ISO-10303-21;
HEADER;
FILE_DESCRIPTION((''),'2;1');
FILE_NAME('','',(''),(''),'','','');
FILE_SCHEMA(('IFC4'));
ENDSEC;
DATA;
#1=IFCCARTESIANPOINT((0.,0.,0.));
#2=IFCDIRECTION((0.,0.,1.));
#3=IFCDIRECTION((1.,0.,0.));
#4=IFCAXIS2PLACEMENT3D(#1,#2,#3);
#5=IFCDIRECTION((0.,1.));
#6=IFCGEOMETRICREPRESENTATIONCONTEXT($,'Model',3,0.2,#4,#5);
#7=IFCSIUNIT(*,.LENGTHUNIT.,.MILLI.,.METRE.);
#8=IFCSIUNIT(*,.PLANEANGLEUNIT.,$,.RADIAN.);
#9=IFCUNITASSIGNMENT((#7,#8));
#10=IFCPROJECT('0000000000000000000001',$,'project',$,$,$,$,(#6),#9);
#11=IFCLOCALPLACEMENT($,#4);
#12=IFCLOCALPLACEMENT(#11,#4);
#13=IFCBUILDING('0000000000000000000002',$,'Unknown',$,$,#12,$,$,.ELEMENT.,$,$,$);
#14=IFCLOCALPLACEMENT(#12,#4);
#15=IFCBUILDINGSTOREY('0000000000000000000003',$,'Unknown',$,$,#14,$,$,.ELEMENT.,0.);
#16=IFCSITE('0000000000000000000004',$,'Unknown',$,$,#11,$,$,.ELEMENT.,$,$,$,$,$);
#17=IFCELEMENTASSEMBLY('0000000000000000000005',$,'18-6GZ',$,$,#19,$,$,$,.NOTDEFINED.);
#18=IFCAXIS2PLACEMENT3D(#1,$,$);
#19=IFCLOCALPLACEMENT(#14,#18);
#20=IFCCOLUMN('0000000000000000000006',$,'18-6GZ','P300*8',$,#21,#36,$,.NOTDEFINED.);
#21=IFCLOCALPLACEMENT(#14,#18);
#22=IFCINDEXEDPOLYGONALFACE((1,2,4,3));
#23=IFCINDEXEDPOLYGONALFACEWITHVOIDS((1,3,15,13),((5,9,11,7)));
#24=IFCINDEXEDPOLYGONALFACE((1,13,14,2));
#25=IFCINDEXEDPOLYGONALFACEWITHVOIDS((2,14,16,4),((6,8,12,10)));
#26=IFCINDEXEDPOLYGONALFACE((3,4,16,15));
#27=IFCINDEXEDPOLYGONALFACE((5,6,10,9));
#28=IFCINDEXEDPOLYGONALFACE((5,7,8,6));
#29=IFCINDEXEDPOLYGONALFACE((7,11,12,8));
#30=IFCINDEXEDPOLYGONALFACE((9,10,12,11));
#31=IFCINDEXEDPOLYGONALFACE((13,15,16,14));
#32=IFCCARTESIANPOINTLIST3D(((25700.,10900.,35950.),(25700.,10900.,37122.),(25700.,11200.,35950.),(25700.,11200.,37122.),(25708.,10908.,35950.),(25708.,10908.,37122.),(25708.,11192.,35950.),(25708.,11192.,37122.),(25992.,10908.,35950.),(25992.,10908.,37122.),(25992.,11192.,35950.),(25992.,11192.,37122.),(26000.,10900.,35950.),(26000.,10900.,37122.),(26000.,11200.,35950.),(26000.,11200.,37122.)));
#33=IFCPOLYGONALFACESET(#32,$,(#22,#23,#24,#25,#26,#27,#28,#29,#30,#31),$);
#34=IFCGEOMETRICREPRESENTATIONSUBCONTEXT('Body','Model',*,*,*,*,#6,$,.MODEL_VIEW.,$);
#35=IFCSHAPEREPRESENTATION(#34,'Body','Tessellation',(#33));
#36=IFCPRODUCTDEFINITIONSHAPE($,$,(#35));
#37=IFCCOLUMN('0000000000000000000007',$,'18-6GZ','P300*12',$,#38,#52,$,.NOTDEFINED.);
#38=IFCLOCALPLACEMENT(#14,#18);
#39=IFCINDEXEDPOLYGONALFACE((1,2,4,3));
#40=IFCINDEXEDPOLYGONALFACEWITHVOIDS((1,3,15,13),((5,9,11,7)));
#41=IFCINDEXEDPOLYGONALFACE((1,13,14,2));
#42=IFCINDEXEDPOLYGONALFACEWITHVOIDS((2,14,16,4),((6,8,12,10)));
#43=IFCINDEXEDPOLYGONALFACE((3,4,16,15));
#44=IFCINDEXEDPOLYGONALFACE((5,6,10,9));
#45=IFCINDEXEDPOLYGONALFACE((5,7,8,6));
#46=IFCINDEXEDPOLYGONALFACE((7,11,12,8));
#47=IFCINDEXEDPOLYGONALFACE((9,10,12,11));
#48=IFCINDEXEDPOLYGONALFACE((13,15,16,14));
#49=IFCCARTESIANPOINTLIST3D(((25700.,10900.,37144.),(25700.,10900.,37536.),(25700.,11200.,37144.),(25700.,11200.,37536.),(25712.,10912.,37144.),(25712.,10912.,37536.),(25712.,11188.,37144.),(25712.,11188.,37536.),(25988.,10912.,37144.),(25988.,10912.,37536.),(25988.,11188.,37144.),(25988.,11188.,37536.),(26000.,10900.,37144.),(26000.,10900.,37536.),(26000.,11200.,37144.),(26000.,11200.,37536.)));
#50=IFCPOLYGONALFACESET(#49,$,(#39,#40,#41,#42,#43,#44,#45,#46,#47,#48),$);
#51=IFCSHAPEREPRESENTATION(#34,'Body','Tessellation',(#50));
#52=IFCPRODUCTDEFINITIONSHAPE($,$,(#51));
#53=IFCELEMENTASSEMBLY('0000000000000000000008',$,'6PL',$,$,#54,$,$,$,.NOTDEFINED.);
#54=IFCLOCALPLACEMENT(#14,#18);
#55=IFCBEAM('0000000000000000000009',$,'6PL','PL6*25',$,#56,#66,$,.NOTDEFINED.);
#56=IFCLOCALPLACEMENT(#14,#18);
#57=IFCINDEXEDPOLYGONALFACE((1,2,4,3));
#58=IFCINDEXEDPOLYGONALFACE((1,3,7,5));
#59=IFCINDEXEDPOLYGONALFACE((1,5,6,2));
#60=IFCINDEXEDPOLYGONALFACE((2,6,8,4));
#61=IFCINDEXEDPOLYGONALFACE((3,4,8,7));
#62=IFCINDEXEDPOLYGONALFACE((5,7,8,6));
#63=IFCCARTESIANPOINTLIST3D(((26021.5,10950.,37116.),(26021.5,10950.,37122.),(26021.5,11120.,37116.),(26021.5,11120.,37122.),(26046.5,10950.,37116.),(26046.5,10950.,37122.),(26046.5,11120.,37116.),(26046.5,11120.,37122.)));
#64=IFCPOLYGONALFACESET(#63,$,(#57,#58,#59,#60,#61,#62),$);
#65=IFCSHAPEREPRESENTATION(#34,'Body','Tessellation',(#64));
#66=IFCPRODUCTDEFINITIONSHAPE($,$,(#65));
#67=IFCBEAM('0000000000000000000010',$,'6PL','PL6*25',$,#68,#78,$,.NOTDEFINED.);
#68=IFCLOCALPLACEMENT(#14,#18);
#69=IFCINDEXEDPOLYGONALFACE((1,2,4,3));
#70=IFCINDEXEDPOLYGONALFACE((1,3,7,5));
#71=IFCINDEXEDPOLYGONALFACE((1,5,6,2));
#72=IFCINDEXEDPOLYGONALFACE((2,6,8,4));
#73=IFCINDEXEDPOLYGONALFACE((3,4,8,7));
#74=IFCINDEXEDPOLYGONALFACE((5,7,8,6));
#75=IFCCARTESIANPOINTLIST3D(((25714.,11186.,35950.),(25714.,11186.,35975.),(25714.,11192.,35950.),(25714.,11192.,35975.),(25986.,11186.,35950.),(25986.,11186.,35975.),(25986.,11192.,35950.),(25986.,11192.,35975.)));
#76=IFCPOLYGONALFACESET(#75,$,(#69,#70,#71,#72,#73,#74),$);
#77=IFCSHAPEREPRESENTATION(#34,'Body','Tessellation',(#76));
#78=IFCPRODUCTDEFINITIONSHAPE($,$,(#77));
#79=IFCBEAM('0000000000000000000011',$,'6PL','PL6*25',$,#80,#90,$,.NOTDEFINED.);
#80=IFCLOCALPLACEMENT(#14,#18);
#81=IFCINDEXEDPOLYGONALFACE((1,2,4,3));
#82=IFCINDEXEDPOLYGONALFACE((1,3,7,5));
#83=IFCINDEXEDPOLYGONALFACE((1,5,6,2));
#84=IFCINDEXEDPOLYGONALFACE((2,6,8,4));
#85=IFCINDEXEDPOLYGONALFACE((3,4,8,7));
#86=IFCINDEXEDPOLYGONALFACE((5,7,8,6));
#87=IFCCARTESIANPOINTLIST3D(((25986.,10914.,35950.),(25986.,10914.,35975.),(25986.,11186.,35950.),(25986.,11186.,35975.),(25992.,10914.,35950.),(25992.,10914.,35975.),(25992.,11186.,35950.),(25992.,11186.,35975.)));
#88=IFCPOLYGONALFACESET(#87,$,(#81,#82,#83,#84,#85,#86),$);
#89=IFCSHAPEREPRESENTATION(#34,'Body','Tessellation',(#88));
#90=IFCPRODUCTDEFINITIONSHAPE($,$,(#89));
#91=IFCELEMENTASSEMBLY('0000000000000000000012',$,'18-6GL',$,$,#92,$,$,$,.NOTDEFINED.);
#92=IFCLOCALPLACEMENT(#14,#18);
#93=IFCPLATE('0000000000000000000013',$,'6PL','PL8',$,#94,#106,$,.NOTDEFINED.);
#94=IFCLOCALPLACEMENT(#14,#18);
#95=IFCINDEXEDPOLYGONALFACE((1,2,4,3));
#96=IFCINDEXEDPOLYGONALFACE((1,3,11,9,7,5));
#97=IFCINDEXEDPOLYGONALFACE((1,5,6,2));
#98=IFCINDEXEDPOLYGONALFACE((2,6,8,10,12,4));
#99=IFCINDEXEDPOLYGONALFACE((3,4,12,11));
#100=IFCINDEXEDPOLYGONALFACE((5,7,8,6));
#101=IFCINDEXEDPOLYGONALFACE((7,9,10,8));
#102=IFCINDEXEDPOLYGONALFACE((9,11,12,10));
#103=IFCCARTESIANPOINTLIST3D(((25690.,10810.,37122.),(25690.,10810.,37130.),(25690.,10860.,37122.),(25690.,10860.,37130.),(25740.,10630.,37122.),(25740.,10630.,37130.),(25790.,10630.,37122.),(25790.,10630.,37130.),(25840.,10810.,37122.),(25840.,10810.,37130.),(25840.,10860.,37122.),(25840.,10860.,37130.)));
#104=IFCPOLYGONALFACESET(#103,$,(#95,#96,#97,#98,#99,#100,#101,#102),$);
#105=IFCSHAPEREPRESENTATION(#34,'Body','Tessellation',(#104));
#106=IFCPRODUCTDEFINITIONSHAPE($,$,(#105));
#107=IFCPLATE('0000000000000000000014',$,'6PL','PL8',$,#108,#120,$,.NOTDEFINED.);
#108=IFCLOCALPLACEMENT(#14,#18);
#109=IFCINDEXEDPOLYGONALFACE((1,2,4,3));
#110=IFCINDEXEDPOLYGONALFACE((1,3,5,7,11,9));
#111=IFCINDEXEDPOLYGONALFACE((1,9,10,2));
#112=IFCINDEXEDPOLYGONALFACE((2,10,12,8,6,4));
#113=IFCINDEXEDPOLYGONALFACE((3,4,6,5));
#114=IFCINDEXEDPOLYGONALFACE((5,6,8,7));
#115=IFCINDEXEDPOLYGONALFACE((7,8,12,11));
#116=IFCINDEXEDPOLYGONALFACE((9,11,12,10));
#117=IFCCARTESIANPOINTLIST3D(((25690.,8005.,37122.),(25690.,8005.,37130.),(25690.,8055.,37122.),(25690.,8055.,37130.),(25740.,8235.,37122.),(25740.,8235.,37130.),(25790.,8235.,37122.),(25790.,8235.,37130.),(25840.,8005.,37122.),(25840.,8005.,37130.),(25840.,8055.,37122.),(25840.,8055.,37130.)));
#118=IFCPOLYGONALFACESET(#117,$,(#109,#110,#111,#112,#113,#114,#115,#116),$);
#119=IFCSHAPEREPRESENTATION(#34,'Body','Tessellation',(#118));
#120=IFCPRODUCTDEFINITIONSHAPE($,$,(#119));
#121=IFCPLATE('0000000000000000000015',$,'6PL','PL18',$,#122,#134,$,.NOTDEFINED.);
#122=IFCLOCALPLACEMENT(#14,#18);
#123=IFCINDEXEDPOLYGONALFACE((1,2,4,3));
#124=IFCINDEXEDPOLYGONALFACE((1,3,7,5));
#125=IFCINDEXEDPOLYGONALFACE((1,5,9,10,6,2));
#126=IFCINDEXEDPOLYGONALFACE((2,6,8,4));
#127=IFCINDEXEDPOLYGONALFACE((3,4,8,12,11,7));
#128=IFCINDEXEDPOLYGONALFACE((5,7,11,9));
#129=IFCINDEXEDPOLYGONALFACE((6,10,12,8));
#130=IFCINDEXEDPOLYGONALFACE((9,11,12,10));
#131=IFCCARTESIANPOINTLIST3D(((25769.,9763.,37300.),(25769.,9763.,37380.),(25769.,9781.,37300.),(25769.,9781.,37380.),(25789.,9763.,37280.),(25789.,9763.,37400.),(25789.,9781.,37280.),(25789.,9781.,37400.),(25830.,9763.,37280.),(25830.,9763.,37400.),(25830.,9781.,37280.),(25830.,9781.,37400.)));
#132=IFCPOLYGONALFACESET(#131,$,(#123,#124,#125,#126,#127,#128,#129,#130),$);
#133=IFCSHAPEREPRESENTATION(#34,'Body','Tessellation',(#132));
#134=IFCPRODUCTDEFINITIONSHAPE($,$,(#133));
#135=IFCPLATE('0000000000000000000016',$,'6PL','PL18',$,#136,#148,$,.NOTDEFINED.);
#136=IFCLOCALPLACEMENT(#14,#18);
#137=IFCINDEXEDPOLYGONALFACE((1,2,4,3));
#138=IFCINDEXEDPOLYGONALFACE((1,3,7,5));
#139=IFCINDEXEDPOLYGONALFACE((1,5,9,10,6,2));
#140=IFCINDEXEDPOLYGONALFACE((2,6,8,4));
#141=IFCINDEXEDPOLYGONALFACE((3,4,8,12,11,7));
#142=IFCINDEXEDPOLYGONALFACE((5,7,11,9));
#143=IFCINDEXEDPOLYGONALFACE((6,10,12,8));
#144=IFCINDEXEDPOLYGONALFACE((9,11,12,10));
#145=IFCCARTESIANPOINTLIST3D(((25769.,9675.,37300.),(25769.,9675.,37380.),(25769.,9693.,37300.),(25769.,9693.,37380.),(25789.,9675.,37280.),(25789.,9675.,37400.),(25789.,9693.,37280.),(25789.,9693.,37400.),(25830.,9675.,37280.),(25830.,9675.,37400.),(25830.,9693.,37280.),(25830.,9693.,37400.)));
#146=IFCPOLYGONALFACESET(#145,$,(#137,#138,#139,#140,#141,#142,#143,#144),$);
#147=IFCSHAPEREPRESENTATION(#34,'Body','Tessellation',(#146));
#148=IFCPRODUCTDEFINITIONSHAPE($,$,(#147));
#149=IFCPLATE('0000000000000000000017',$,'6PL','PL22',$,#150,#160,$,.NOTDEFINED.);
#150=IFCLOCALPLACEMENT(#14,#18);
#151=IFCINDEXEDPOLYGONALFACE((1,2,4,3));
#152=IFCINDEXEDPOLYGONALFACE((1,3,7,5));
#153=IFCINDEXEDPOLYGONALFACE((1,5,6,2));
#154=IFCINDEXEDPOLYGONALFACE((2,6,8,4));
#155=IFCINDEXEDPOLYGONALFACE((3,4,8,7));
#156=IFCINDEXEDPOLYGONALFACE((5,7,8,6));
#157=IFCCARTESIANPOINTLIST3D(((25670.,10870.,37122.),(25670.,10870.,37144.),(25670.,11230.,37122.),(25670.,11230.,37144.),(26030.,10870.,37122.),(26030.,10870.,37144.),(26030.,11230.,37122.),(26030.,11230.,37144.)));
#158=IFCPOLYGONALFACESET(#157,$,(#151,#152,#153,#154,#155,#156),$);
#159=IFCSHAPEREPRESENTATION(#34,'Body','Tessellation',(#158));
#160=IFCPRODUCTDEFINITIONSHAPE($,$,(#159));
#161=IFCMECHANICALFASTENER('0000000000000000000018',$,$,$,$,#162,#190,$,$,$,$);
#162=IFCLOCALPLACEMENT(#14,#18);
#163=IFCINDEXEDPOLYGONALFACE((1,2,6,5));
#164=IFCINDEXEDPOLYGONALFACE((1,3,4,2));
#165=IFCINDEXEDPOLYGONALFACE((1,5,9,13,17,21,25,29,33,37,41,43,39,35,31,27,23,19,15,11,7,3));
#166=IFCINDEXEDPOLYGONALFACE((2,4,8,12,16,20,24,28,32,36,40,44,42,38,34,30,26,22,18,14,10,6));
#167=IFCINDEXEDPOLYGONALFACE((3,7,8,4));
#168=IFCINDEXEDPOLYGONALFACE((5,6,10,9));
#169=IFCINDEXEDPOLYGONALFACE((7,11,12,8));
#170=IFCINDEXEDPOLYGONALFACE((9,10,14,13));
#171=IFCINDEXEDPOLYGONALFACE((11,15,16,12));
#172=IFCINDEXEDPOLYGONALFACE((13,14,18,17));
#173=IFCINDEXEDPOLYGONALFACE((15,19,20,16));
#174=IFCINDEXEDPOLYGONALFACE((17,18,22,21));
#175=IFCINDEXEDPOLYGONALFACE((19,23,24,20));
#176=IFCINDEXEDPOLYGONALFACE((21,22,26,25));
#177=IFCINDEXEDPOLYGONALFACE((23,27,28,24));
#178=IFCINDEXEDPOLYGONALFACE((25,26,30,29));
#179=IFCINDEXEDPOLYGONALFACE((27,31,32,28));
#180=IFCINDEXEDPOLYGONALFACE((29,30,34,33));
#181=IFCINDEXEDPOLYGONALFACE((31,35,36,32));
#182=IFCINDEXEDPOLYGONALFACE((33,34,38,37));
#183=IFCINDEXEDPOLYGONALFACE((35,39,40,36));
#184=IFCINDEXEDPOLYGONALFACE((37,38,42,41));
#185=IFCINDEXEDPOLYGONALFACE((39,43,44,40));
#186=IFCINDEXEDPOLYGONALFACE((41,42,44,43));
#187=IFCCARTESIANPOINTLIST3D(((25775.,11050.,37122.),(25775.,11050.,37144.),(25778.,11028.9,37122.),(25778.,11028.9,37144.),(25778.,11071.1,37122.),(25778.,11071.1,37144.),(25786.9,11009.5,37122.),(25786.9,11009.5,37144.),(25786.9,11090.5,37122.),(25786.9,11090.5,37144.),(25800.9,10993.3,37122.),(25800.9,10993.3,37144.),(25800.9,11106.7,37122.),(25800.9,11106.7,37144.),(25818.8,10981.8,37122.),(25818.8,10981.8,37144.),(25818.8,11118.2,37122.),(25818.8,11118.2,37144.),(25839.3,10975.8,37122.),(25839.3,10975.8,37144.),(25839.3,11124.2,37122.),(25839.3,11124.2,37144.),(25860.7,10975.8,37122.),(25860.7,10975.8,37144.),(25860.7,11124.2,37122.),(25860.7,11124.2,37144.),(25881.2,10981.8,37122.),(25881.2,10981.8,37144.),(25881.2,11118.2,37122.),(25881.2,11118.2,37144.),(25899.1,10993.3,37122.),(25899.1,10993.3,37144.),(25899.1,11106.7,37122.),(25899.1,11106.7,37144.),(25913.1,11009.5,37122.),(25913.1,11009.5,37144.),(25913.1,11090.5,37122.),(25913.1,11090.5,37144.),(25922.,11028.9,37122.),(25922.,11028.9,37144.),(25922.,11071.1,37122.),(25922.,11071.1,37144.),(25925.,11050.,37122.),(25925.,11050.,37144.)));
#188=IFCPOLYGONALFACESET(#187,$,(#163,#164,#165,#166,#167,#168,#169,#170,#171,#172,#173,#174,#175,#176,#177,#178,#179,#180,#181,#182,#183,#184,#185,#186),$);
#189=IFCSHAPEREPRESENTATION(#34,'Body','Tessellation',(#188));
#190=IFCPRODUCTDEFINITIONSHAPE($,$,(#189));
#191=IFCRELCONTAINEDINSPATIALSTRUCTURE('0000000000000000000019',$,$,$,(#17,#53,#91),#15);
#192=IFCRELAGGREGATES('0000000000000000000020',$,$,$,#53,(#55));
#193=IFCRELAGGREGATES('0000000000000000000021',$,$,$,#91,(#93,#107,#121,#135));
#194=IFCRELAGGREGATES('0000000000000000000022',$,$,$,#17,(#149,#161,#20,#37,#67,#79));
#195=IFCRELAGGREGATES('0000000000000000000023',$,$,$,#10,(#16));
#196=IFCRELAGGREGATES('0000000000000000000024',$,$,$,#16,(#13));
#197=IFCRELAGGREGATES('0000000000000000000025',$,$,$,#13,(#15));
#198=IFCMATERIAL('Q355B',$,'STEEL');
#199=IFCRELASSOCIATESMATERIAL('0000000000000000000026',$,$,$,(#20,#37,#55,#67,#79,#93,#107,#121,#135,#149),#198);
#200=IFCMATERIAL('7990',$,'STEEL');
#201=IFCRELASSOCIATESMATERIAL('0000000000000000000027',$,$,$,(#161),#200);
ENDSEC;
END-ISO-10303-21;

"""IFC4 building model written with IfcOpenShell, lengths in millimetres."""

from ifc_helpers import new_model, si_unit, direction, frame, origin_with_axes, place, context, subcontext, project, spatial, line, arc, indexed_curve, outline, extrude, source, transform, mapped, material, element, aggregate, save


model = new_model("IFC4")

# Units and contexts
model_context = context("Model", 3, precision=0.2, world=origin_with_axes(), true_north=direction((0.0, 1.0)))
body_context = subcontext(model_context, "Body", "Model", "MODEL_VIEW")
ifc_project = project(units=[si_unit("LENGTHUNIT", "METRE", prefix="MILLI"), si_unit("PLANEANGLEUNIT", "RADIAN")], contexts=[model_context])

# Site, building, storey
site_placement = place(None, origin_with_axes())
site = spatial("IfcSite", under=ifc_project, at=site_placement, Name="Unknown", CompositionType="ELEMENT")
building_placement = place(site_placement, origin_with_axes())
building = spatial("IfcBuilding", under=site, at=building_placement, Name="Unknown", CompositionType="ELEMENT")
storey_placement = place(building_placement, origin_with_axes())
storey = spatial("IfcBuildingStorey", under=building, at=storey_placement, Name="Unknown", CompositionType="ELEMENT", Elevation=0.0)

# Element assembly, columns
assembly_1_placement = place(storey_placement, frame((25850.0, 11050.0, 35950.0), z_axis=(-1.0, 0.0, 0.0), x_axis=(0.0, 0.0, 1.0)))
assembly_1 = element("IfcElementAssembly", 1, at=assembly_1_placement, inside=storey, Name="18-6GZ", PredefinedType="NOTDEFINED")
ifc_material_1 = material(Name="Q355B", Category="STEEL")
column_1_placement = place(assembly_1_placement, origin_with_axes())
column_1 = element("IfcColumn", 2, at=column_1_placement, material=ifc_material_1, Name="18-6GZ", Description="P300*8", PredefinedType="NOTDEFINED", context=body_context, shape_type="SolidModel", body=[
    extrude(outline(indexed_curve([(-150.0, -150.0), (150.0, -150.0), (150.0, 150.0), (-150.0, 150.0)], segments=[line(1, 2, 3, 4, 1)]), holes=[indexed_curve([(-142.0, -142.0), (-142.0, 142.0), (142.0, 142.0), (142.0, -142.0)], segments=[line(1, 2, 3, 4, 1)])]), frame((0.0, 0.0, 0.0), z_axis=(-1.0, 0.0, 0.0), x_axis=(0.0, 0.0, 1.0)), (0.0, 0.0, -1.0), 1172.0),
])
column_2_placement = place(assembly_1_placement, frame((1194.0, 0.0, 0.0), z_axis=(0.0, 0.0, 1.0), x_axis=(1.0, 0.0, 0.0)))
column_2 = element("IfcColumn", 3, at=column_2_placement, material=ifc_material_1, Name="18-6GZ", Description="P300*12", PredefinedType="NOTDEFINED", context=body_context, shape_type="SolidModel", body=[
    extrude(outline(indexed_curve([(-150.0, -150.0), (150.0, -150.0), (150.0, 150.0), (-150.0, 150.0)], segments=[line(1, 2, 3, 4, 1)]), holes=[indexed_curve([(-138.0, -138.0), (-138.0, 138.0), (138.0, 138.0), (138.0, -138.0)], segments=[line(1, 2, 3, 4, 1)])]), frame((0.0, 0.0, 0.0), z_axis=(-1.0, 0.0, 0.0), x_axis=(0.0, 0.0, 1.0)), (0.0, 0.0, -1.0), 392.0),
])

# Element assembly, beam
assembly_2_placement = place(storey_placement, frame((26034.0, 10950.0, 37119.0), z_axis=(0.0, 0.0, -1.0), x_axis=(0.0, 1.0, 0.0)))
assembly_2 = element("IfcElementAssembly", 4, at=assembly_2_placement, inside=storey, Name="6PL", PredefinedType="NOTDEFINED")
beam_1_placement = place(assembly_2_placement, origin_with_axes())
beam_1 = element("IfcBeam", 5, at=beam_1_placement, material=ifc_material_1, Name="6PL", Description="PL6*25", PredefinedType="NOTDEFINED", context=body_context, shape_type="SolidModel", body=[
    extrude(outline(indexed_curve([(-3.0, -12.5), (3.0, -12.5), (3.0, 12.5), (-3.0, 12.5)], segments=[line(1, 2, 3, 4, 1)])), frame((0.0, 0.0, 0.0), z_axis=(-1.0, 0.0, 0.0), x_axis=(0.0, 0.0, 1.0)), (0.0, 0.0, -1.0), 170.0),
])
aggregate(assembly_2, [beam_1])

# Beams
beam_2_placement = place(assembly_1_placement, frame((12.5, 139.0, -136.0), z_axis=(0.0, 1.0, 0.0), x_axis=(0.0, 0.0, 1.0)))
beam_2 = element("IfcBeam", 6, at=beam_2_placement, material=ifc_material_1, Name="6PL", Description="PL6*25", PredefinedType="NOTDEFINED", context=body_context, shape_type="SolidModel", body=[
    extrude(outline(indexed_curve([(-3.0, -12.5), (3.0, -12.5), (3.0, 12.5), (-3.0, 12.5)], segments=[line(1, 2, 3, 4, 1)])), frame((0.0, 0.0, 0.0), z_axis=(-1.0, 0.0, 0.0), x_axis=(0.0, 0.0, 1.0)), (0.0, 0.0, -1.0), 272.0),
])
beam_3_placement = place(assembly_1_placement, frame((12.5, -136.0, -139.0), z_axis=(0.0, 0.0, -1.0), x_axis=(0.0, 1.0, 0.0)))
beam_3 = element("IfcBeam", 7, at=beam_3_placement, material=ifc_material_1, Name="6PL", Description="PL6*25", PredefinedType="NOTDEFINED", context=body_context, shape_type="SolidModel", body=[
    extrude(outline(indexed_curve([(-3.0, -12.5), (3.0, -12.5), (3.0, 12.5), (-3.0, 12.5)], segments=[line(1, 2, 3, 4, 1)])), frame((0.0, 0.0, 0.0), z_axis=(-1.0, 0.0, 0.0), x_axis=(0.0, 0.0, 1.0)), (0.0, 0.0, -1.0), 272.0),
])

# Element assembly, plates
assembly_3_placement = place(storey_placement, frame((25765.0, 10900.0, 37340.0), z_axis=(-1.0, 0.0, 0.0), x_axis=(0.0, -1.0, 0.0)))
assembly_3 = element("IfcElementAssembly", 8, at=assembly_3_placement, inside=storey, Name="18-6GL", PredefinedType="NOTDEFINED")
plate_1_placement = place(assembly_3_placement, frame((90.0, -214.0, -75.0), z_axis=(0.0, 1.0, 0.0), x_axis=(-1.0, 0.0, 0.0)))
plate_1 = element("IfcPlate", 9, at=plate_1_placement, material=ifc_material_1, Name="6PL", Description="PL8", PredefinedType="NOTDEFINED", context=body_context, shape_type="SolidModel", body=[
    extrude(outline(indexed_curve([(0.0, 0.0), (50.0, 0.0), (50.0, 150.0), (0.0, 150.0), (-180.0, 100.0), (-180.0, 50.0)], segments=[line(1, 2, 3, 4, 5, 6, 1)])), frame((0.0, 0.0, 4.0), z_axis=(0.0, 0.0, 1.0), x_axis=(1.0, 0.0, 0.0)), (0.0, 0.0, -1.0), 8.0),
])
plate_2_placement = place(assembly_3_placement, frame((2845.0, -214.0, -75.0), z_axis=(0.0, -1.0, 0.0), x_axis=(1.0, 0.0, 0.0)))
plate_2 = element("IfcPlate", 10, at=plate_2_placement, material=ifc_material_1, Name="6PL", Description="PL8", PredefinedType="NOTDEFINED", context=body_context, shape_type="SolidModel", body=[
    extrude(outline(indexed_curve([(0.0, 0.0), (50.0, 0.0), (50.0, 150.0), (0.0, 150.0), (-180.0, 100.0), (-180.0, 50.0)], segments=[line(1, 2, 3, 4, 5, 6, 1)])), frame((0.0, 0.0, 4.0), z_axis=(0.0, 0.0, 1.0), x_axis=(1.0, 0.0, 0.0)), (0.0, 0.0, -1.0), 8.0),
])
plate_3_placement = place(assembly_3_placement, frame((1128.0, -60.0, -65.0), z_axis=(-1.0, 0.0, 0.0), x_axis=(0.0, 0.0, 1.0)))
plate_3 = element("IfcPlate", 11, at=plate_3_placement, material=ifc_material_1, Name="6PL", Description="PL18", PredefinedType="NOTDEFINED", context=body_context, shape_type="SolidModel", body=[
    extrude(outline(indexed_curve([(0.0, 0.0), (41.0, 0.0), (61.0, 20.0), (61.0, 100.0), (41.0, 120.0), (0.0, 120.0)], segments=[line(1, 2, 3, 4, 5, 6, 1)])), frame((0.0, 0.0, 9.0), z_axis=(0.0, 0.0, 1.0), x_axis=(1.0, 0.0, 0.0)), (0.0, 0.0, -1.0), 18.0),
])
plate_4_placement = place(assembly_3_placement, frame((1216.0, -60.0, -65.0), z_axis=(-1.0, 0.0, 0.0), x_axis=(0.0, 0.0, 1.0)))
plate_4 = element("IfcPlate", 12, at=plate_4_placement, material=ifc_material_1, Name="6PL", Description="PL18", PredefinedType="NOTDEFINED", context=body_context, shape_type="SolidModel", body=[
    extrude(outline(indexed_curve([(0.0, 0.0), (41.0, 0.0), (61.0, 20.0), (61.0, 100.0), (41.0, 120.0), (0.0, 120.0)], segments=[line(1, 2, 3, 4, 5, 6, 1)])), frame((0.0, 0.0, 9.0), z_axis=(0.0, 0.0, 1.0), x_axis=(1.0, 0.0, 0.0)), (0.0, 0.0, -1.0), 18.0),
])
aggregate(assembly_3, [plate_1, plate_2, plate_3, plate_4])

# Plate
plate_5_placement = place(assembly_1_placement, frame((1183.0, -180.0, -180.0), z_axis=(-1.0, 0.0, 0.0), x_axis=(0.0, 0.0, 1.0)))
plate_5 = element("IfcPlate", 13, at=plate_5_placement, material=ifc_material_1, Name="6PL", Description="PL22", PredefinedType="NOTDEFINED", context=body_context, shape_type="SolidModel", body=[
    extrude(outline(indexed_curve([(0.0, 0.0), (360.0, 0.0), (360.0, 360.0), (0.0, 360.0)], segments=[line(1, 2, 3, 4, 1)])), frame((0.0, 0.0, 11.0), z_axis=(0.0, 0.0, 1.0), x_axis=(1.0, 0.0, 0.0)), (0.0, 0.0, -1.0), 22.0),
])

# Mechanical fastener
ifc_material_2 = material(Name="7990", Category="STEEL")
shared_shape_1 = source(origin_with_axes(), body_context, "Body", "SweptSolid", [
    extrude(outline(indexed_curve([(75.0, 0.0), (0.0, 75.0), (-75.0, 0.0), (0.0, -75.0)], segments=[arc(1, 2, 3), arc(3, 4, 1)])), frame((0.0, 0.0, 0.0), z_axis=(0.0, 0.0, -1.0), x_axis=(0.0, 1.0, 0.0)), (0.0, 0.0, 1.0), 22.0),
])
placement_1 = place(assembly_1_placement, frame((1172.0, 0.0, 0.0), z_axis=(-1.0, 0.0, 0.0), x_axis=(0.0, 1.0, 0.0)))
mechanical_fastener_1 = element("IfcMechanicalFastener", 14, at=placement_1, material=ifc_material_2, context=body_context, shape_type="MappedRepresentation", body=[
    mapped(shared_shape_1, transform((0.0, 0.0, 0.0))),
])
aggregate(assembly_1, [plate_5, mechanical_fastener_1, column_1, column_2, beam_2, beam_3])

save(model, "model.ifc")
